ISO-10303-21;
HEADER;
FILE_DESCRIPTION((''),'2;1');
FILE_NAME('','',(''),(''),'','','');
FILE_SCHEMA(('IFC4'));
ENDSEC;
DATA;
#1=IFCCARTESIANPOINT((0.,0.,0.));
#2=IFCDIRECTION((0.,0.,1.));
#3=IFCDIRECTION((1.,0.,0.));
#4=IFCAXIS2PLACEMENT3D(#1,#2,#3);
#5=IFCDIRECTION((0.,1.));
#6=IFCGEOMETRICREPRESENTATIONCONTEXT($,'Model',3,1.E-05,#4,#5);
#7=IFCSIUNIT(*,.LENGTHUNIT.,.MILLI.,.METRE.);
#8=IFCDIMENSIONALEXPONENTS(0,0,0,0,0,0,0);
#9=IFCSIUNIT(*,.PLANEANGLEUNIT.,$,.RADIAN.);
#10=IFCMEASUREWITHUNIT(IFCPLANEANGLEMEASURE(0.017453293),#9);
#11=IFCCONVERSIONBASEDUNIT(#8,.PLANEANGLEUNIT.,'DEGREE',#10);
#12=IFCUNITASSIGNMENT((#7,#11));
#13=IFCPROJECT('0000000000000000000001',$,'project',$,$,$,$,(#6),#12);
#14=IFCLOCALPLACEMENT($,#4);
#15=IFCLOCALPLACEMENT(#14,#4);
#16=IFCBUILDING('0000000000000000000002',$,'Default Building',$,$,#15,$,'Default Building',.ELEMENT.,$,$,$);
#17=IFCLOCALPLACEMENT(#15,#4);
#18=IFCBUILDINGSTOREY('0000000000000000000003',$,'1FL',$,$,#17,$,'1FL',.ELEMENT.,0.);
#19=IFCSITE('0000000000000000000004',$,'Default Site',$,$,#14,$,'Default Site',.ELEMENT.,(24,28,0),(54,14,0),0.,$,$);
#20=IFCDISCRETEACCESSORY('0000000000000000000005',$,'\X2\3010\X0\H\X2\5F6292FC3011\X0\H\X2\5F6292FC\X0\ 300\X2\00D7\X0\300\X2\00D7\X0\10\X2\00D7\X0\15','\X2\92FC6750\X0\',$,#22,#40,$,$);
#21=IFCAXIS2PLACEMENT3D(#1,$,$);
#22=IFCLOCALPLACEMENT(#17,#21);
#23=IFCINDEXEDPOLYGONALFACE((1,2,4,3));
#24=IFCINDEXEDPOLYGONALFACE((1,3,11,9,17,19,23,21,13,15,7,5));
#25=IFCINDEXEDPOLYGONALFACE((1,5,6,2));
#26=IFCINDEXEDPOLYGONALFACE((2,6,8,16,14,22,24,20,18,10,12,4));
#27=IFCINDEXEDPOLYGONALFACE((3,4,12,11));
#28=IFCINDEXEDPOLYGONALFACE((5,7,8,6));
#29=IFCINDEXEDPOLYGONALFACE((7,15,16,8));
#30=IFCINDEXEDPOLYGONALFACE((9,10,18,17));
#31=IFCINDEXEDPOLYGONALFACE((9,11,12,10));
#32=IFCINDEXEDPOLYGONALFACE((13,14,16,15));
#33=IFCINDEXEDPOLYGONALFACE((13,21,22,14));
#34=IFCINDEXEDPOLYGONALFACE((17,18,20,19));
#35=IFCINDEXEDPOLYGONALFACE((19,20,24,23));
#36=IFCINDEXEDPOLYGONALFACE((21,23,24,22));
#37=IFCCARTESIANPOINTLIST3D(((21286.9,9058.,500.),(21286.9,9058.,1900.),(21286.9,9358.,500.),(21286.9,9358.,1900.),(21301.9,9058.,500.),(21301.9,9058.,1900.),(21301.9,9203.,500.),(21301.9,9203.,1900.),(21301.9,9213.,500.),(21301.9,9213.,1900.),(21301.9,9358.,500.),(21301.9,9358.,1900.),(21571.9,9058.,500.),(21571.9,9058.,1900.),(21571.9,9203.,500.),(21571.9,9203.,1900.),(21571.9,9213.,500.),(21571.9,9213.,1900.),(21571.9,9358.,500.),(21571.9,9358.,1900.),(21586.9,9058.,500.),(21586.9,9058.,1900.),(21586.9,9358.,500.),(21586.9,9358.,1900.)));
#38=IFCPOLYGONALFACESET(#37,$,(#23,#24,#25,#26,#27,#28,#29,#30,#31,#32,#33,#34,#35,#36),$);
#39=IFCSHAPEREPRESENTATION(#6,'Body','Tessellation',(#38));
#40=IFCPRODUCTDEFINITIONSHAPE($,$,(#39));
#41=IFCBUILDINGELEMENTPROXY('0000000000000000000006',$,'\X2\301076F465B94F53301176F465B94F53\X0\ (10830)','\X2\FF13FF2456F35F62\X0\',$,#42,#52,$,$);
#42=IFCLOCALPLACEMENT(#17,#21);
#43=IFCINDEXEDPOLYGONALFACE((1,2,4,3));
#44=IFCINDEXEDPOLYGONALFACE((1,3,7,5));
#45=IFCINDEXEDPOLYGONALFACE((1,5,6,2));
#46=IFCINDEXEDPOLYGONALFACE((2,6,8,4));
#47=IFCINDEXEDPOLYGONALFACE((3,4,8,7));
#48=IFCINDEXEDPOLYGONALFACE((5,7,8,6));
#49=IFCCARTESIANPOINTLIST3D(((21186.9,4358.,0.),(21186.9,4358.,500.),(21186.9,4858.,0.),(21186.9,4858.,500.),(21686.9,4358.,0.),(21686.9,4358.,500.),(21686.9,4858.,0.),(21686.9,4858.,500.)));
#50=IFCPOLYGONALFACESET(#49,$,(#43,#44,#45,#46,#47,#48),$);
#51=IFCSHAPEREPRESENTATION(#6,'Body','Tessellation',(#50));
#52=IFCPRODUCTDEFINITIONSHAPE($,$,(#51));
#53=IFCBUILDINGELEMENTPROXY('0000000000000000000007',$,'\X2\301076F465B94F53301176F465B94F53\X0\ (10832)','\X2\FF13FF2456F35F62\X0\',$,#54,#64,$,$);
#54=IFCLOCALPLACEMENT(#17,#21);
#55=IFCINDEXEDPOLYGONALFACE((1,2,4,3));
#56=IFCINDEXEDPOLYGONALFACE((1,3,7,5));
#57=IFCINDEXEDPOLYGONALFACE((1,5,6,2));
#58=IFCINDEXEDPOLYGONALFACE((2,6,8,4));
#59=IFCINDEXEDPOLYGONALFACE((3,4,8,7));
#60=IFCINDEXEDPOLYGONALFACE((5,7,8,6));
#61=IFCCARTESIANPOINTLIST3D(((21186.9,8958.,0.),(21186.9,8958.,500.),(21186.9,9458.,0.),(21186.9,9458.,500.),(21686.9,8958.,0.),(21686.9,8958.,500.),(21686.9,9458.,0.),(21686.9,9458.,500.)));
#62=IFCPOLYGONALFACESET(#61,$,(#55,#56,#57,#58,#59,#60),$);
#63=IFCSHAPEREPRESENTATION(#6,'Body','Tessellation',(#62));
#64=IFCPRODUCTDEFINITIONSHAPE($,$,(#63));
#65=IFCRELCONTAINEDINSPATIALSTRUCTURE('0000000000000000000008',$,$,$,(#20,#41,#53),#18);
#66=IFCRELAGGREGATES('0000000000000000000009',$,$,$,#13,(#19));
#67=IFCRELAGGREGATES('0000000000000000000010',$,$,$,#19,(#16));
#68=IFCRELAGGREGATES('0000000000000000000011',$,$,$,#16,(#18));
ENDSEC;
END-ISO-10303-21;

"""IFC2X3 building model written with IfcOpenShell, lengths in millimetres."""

from ifc_helpers import new_model, entity, si_unit, converted_unit, direction, frame, origin_with_axes, origin_2d_with_axis, place, context, project, spatial, rectangle, i_section, extrude, source, transform, mapped, element, save


model = new_model("IFC2X3")

# Units and contexts
model_context = context("Model", 3, precision=1e-05, world=origin_with_axes(), true_north=direction((0.0, 1.0)))
ifc_project = project(units=[si_unit("LENGTHUNIT", "METRE", prefix="MILLI"), converted_unit("PLANEANGLEUNIT", "DEGREE", entity("IfcPlaneAngleMeasure", 0.017453293), si_unit("PLANEANGLEUNIT", "RADIAN"), dimensions=[0, 0, 0, 0, 0, 0, 0])], contexts=[model_context])

# Site, building, storey
site_placement = place(None, origin_with_axes())
site = spatial("IfcSite", under=ifc_project, at=site_placement, Name="Default Site", LongName="Default Site", CompositionType="ELEMENT", RefLatitude=(24, 28, 0), RefLongitude=(54, 14, 0), RefElevation=0.0)
building_placement = place(site_placement, origin_with_axes())
building = spatial("IfcBuilding", under=site, at=building_placement, Name="Default Building", LongName="Default Building", CompositionType="ELEMENT")
storey_placement = place(building_placement, origin_with_axes())
storey = spatial("IfcBuildingStorey", under=building, at=storey_placement, Name="1FL", LongName="1FL", CompositionType="ELEMENT", Elevation=0.0)

# Discrete accessory
shared_shape_1 = source(origin_with_axes(), model_context, "Body", "SweptSolid", [
    extrude(i_section(OverallWidth=300.0, OverallDepth=300.0, WebThickness=10.0, FlangeThickness=15.0, at=origin_2d_with_axis()), frame((700.0, 0.0, -150.0), z_axis=(-1.0, 0.0, 0.0), x_axis=(0.0, -1.0, 0.0)), (0.0, 0.0, 1.0), 1400.0),
])
discrete_accessory_1_placement = place(storey_placement, frame((21286.9, 9208.0, 1200.0), z_axis=(-1.0, 0.0, 0.0), x_axis=(0.0, 0.0, 1.0)))
element("IfcDiscreteAccessory", 1, at=discrete_accessory_1_placement, inside=storey, Name="【H形鋼】H形鋼 300×300×10×15", Description="鋼材", context=model_context, shape_type="MappedRepresentation", body=[
    mapped(shared_shape_1, transform((0.0, 0.0, 0.0))),
])

# Building element proxies
shared_shape_2 = source(origin_with_axes(), model_context, "Body", "SweptSolid", [
    extrude(rectangle(XDim=500.0, YDim=500.0, at=origin_2d_with_axis()), origin_with_axes(), (0.0, 0.0, 1.0), 500.0),
])
proxy_1_placement = place(storey_placement, frame((21436.9, 4608.0, 0.0), z_axis=(0.0, 0.0, 1.0), x_axis=(1.0, 0.0, 0.0)))
element("IfcBuildingElementProxy", 2, at=proxy_1_placement, inside=storey, Name="【直方体】直方体 (10830)", Description="３Ｄ図形", context=model_context, shape_type="MappedRepresentation", body=[
    mapped(shared_shape_2, transform((0.0, 0.0, 0.0))),
])
shared_shape_3 = source(origin_with_axes(), model_context, "Body", "SweptSolid", [
    extrude(rectangle(XDim=500.0, YDim=500.0, at=origin_2d_with_axis()), origin_with_axes(), (0.0, 0.0, 1.0), 500.0),
])
proxy_2_placement = place(storey_placement, frame((21436.9, 9208.0, 0.0), z_axis=(0.0, 0.0, 1.0), x_axis=(1.0, 0.0, 0.0)))
element("IfcBuildingElementProxy", 3, at=proxy_2_placement, inside=storey, Name="【直方体】直方体 (10832)", Description="３Ｄ図形", context=model_context, shape_type="MappedRepresentation", body=[
    mapped(shared_shape_3, transform((0.0, 0.0, 0.0))),
])

save(model, "model.ifc")
